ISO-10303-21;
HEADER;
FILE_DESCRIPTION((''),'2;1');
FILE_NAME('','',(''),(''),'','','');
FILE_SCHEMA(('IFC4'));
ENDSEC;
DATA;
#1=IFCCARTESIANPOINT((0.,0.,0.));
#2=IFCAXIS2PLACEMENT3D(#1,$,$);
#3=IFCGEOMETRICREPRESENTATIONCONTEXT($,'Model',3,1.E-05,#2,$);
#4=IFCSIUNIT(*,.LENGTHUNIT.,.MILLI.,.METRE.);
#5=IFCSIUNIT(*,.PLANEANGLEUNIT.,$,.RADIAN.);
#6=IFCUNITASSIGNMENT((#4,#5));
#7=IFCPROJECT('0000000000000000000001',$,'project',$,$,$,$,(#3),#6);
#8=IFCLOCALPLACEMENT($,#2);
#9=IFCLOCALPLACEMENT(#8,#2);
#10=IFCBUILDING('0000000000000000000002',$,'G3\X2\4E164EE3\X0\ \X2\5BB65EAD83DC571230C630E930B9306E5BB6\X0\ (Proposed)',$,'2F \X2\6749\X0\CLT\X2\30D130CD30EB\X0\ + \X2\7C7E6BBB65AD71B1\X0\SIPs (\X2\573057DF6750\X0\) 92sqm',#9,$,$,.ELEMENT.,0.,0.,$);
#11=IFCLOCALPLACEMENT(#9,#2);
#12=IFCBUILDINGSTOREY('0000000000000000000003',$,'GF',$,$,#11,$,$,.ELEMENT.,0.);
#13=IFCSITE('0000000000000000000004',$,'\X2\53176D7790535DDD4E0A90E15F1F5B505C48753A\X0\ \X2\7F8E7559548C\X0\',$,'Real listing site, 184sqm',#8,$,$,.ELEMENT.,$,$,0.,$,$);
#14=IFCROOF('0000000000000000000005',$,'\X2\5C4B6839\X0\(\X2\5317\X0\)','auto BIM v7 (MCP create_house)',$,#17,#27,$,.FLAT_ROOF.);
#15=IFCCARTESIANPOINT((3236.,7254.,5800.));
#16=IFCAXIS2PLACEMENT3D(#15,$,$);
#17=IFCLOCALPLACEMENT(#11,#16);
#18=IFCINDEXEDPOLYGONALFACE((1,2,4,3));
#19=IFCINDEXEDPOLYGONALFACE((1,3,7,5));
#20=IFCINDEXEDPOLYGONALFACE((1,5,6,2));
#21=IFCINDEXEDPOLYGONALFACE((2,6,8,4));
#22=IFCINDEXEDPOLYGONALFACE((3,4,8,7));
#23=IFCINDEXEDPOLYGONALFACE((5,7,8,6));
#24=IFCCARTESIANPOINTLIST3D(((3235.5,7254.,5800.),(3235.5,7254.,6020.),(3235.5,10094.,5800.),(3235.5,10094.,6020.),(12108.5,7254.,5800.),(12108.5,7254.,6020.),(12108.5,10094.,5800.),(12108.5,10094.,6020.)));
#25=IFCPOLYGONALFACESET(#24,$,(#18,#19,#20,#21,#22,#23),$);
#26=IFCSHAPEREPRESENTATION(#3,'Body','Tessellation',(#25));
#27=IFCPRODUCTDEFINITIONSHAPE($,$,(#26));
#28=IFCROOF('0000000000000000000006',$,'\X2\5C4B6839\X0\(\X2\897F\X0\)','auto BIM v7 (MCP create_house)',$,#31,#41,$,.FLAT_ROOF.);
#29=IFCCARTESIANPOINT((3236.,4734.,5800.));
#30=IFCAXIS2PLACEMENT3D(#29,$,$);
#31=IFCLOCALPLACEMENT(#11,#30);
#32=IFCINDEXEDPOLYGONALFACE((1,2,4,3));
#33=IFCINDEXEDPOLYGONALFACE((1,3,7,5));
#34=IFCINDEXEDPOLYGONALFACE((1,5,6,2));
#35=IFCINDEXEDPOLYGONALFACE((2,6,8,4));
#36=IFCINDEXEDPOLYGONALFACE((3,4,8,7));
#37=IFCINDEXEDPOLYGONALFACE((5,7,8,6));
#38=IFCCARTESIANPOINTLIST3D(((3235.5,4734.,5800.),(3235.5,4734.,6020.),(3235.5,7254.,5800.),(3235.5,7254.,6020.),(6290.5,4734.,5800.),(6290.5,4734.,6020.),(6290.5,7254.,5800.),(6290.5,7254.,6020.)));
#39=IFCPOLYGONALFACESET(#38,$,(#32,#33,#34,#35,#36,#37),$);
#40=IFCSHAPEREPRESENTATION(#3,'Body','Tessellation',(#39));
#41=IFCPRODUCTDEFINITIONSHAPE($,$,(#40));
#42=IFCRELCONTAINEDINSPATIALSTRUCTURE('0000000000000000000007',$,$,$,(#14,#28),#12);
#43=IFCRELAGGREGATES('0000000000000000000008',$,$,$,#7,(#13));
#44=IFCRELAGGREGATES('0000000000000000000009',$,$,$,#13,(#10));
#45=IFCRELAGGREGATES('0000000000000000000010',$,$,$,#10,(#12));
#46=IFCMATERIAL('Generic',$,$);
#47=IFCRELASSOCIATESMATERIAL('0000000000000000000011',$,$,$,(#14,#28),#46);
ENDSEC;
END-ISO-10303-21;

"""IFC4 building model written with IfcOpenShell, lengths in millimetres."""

from ifc_helpers import new_model, si_unit, frame, frame_2d, origin, place, context, project, spatial, rectangle, extrude, material, element, save


model = new_model("IFC4")

# Units and contexts
model_context = context("Model", 3, precision=1e-05, world=origin())
ifc_project = project(units=[si_unit("LENGTHUNIT", "METRE", prefix="MILLI"), si_unit("PLANEANGLEUNIT", "RADIAN")], contexts=[model_context])

# Site, building, storey
site_placement = place(None, origin())
site = spatial("IfcSite", under=ifc_project, at=site_placement, Name="北海道川上郡弟子屈町 美留和", ObjectType="Real listing site, 184sqm", CompositionType="ELEMENT", RefElevation=0.0)
building_placement = place(site_placement, origin())
building = spatial("IfcBuilding", under=site, at=building_placement, Name="G3世代 家庭菜園テラスの家 (Proposed)", ObjectType="2F 杉CLTパネル + 籾殻断熱SIPs (地域材) 92sqm", CompositionType="ELEMENT", ElevationOfRefHeight=0.0, ElevationOfTerrain=0.0)
storey_placement = place(building_placement, origin())
storey = spatial("IfcBuildingStorey", under=building, at=storey_placement, Name="GF", CompositionType="ELEMENT", Elevation=0.0)

# Shared definitions
ifc_material = material(Name="Generic")

# Roofs
roof_1_placement = place(storey_placement, frame((3236.0, 7254.0, 5800.0)))
element("IfcRoof", 1, at=roof_1_placement, inside=storey, material=ifc_material, Name="屋根(北)", Description="auto BIM v7 (MCP create_house)", PredefinedType="FLAT_ROOF", context=model_context, shape_type="SweptSolid", body=[
    extrude(rectangle(XDim=8873.0, YDim=2840.0, at=frame_2d((4436.0, 1420.0))), frame((3236.0, 7254.0, 5800.0)), (0.0, 0.0, 1.0), 220.0),
])
roof_2_placement = place(storey_placement, frame((3236.0, 4734.0, 5800.0)))
element("IfcRoof", 2, at=roof_2_placement, inside=storey, material=ifc_material, Name="屋根(西)", Description="auto BIM v7 (MCP create_house)", PredefinedType="FLAT_ROOF", context=model_context, shape_type="SweptSolid", body=[
    extrude(rectangle(XDim=3055.0, YDim=2520.0, at=frame_2d((1527.0, 1260.0))), frame((3236.0, 4734.0, 5800.0)), (0.0, 0.0, 1.0), 220.0),
])

save(model, "model.ifc")
